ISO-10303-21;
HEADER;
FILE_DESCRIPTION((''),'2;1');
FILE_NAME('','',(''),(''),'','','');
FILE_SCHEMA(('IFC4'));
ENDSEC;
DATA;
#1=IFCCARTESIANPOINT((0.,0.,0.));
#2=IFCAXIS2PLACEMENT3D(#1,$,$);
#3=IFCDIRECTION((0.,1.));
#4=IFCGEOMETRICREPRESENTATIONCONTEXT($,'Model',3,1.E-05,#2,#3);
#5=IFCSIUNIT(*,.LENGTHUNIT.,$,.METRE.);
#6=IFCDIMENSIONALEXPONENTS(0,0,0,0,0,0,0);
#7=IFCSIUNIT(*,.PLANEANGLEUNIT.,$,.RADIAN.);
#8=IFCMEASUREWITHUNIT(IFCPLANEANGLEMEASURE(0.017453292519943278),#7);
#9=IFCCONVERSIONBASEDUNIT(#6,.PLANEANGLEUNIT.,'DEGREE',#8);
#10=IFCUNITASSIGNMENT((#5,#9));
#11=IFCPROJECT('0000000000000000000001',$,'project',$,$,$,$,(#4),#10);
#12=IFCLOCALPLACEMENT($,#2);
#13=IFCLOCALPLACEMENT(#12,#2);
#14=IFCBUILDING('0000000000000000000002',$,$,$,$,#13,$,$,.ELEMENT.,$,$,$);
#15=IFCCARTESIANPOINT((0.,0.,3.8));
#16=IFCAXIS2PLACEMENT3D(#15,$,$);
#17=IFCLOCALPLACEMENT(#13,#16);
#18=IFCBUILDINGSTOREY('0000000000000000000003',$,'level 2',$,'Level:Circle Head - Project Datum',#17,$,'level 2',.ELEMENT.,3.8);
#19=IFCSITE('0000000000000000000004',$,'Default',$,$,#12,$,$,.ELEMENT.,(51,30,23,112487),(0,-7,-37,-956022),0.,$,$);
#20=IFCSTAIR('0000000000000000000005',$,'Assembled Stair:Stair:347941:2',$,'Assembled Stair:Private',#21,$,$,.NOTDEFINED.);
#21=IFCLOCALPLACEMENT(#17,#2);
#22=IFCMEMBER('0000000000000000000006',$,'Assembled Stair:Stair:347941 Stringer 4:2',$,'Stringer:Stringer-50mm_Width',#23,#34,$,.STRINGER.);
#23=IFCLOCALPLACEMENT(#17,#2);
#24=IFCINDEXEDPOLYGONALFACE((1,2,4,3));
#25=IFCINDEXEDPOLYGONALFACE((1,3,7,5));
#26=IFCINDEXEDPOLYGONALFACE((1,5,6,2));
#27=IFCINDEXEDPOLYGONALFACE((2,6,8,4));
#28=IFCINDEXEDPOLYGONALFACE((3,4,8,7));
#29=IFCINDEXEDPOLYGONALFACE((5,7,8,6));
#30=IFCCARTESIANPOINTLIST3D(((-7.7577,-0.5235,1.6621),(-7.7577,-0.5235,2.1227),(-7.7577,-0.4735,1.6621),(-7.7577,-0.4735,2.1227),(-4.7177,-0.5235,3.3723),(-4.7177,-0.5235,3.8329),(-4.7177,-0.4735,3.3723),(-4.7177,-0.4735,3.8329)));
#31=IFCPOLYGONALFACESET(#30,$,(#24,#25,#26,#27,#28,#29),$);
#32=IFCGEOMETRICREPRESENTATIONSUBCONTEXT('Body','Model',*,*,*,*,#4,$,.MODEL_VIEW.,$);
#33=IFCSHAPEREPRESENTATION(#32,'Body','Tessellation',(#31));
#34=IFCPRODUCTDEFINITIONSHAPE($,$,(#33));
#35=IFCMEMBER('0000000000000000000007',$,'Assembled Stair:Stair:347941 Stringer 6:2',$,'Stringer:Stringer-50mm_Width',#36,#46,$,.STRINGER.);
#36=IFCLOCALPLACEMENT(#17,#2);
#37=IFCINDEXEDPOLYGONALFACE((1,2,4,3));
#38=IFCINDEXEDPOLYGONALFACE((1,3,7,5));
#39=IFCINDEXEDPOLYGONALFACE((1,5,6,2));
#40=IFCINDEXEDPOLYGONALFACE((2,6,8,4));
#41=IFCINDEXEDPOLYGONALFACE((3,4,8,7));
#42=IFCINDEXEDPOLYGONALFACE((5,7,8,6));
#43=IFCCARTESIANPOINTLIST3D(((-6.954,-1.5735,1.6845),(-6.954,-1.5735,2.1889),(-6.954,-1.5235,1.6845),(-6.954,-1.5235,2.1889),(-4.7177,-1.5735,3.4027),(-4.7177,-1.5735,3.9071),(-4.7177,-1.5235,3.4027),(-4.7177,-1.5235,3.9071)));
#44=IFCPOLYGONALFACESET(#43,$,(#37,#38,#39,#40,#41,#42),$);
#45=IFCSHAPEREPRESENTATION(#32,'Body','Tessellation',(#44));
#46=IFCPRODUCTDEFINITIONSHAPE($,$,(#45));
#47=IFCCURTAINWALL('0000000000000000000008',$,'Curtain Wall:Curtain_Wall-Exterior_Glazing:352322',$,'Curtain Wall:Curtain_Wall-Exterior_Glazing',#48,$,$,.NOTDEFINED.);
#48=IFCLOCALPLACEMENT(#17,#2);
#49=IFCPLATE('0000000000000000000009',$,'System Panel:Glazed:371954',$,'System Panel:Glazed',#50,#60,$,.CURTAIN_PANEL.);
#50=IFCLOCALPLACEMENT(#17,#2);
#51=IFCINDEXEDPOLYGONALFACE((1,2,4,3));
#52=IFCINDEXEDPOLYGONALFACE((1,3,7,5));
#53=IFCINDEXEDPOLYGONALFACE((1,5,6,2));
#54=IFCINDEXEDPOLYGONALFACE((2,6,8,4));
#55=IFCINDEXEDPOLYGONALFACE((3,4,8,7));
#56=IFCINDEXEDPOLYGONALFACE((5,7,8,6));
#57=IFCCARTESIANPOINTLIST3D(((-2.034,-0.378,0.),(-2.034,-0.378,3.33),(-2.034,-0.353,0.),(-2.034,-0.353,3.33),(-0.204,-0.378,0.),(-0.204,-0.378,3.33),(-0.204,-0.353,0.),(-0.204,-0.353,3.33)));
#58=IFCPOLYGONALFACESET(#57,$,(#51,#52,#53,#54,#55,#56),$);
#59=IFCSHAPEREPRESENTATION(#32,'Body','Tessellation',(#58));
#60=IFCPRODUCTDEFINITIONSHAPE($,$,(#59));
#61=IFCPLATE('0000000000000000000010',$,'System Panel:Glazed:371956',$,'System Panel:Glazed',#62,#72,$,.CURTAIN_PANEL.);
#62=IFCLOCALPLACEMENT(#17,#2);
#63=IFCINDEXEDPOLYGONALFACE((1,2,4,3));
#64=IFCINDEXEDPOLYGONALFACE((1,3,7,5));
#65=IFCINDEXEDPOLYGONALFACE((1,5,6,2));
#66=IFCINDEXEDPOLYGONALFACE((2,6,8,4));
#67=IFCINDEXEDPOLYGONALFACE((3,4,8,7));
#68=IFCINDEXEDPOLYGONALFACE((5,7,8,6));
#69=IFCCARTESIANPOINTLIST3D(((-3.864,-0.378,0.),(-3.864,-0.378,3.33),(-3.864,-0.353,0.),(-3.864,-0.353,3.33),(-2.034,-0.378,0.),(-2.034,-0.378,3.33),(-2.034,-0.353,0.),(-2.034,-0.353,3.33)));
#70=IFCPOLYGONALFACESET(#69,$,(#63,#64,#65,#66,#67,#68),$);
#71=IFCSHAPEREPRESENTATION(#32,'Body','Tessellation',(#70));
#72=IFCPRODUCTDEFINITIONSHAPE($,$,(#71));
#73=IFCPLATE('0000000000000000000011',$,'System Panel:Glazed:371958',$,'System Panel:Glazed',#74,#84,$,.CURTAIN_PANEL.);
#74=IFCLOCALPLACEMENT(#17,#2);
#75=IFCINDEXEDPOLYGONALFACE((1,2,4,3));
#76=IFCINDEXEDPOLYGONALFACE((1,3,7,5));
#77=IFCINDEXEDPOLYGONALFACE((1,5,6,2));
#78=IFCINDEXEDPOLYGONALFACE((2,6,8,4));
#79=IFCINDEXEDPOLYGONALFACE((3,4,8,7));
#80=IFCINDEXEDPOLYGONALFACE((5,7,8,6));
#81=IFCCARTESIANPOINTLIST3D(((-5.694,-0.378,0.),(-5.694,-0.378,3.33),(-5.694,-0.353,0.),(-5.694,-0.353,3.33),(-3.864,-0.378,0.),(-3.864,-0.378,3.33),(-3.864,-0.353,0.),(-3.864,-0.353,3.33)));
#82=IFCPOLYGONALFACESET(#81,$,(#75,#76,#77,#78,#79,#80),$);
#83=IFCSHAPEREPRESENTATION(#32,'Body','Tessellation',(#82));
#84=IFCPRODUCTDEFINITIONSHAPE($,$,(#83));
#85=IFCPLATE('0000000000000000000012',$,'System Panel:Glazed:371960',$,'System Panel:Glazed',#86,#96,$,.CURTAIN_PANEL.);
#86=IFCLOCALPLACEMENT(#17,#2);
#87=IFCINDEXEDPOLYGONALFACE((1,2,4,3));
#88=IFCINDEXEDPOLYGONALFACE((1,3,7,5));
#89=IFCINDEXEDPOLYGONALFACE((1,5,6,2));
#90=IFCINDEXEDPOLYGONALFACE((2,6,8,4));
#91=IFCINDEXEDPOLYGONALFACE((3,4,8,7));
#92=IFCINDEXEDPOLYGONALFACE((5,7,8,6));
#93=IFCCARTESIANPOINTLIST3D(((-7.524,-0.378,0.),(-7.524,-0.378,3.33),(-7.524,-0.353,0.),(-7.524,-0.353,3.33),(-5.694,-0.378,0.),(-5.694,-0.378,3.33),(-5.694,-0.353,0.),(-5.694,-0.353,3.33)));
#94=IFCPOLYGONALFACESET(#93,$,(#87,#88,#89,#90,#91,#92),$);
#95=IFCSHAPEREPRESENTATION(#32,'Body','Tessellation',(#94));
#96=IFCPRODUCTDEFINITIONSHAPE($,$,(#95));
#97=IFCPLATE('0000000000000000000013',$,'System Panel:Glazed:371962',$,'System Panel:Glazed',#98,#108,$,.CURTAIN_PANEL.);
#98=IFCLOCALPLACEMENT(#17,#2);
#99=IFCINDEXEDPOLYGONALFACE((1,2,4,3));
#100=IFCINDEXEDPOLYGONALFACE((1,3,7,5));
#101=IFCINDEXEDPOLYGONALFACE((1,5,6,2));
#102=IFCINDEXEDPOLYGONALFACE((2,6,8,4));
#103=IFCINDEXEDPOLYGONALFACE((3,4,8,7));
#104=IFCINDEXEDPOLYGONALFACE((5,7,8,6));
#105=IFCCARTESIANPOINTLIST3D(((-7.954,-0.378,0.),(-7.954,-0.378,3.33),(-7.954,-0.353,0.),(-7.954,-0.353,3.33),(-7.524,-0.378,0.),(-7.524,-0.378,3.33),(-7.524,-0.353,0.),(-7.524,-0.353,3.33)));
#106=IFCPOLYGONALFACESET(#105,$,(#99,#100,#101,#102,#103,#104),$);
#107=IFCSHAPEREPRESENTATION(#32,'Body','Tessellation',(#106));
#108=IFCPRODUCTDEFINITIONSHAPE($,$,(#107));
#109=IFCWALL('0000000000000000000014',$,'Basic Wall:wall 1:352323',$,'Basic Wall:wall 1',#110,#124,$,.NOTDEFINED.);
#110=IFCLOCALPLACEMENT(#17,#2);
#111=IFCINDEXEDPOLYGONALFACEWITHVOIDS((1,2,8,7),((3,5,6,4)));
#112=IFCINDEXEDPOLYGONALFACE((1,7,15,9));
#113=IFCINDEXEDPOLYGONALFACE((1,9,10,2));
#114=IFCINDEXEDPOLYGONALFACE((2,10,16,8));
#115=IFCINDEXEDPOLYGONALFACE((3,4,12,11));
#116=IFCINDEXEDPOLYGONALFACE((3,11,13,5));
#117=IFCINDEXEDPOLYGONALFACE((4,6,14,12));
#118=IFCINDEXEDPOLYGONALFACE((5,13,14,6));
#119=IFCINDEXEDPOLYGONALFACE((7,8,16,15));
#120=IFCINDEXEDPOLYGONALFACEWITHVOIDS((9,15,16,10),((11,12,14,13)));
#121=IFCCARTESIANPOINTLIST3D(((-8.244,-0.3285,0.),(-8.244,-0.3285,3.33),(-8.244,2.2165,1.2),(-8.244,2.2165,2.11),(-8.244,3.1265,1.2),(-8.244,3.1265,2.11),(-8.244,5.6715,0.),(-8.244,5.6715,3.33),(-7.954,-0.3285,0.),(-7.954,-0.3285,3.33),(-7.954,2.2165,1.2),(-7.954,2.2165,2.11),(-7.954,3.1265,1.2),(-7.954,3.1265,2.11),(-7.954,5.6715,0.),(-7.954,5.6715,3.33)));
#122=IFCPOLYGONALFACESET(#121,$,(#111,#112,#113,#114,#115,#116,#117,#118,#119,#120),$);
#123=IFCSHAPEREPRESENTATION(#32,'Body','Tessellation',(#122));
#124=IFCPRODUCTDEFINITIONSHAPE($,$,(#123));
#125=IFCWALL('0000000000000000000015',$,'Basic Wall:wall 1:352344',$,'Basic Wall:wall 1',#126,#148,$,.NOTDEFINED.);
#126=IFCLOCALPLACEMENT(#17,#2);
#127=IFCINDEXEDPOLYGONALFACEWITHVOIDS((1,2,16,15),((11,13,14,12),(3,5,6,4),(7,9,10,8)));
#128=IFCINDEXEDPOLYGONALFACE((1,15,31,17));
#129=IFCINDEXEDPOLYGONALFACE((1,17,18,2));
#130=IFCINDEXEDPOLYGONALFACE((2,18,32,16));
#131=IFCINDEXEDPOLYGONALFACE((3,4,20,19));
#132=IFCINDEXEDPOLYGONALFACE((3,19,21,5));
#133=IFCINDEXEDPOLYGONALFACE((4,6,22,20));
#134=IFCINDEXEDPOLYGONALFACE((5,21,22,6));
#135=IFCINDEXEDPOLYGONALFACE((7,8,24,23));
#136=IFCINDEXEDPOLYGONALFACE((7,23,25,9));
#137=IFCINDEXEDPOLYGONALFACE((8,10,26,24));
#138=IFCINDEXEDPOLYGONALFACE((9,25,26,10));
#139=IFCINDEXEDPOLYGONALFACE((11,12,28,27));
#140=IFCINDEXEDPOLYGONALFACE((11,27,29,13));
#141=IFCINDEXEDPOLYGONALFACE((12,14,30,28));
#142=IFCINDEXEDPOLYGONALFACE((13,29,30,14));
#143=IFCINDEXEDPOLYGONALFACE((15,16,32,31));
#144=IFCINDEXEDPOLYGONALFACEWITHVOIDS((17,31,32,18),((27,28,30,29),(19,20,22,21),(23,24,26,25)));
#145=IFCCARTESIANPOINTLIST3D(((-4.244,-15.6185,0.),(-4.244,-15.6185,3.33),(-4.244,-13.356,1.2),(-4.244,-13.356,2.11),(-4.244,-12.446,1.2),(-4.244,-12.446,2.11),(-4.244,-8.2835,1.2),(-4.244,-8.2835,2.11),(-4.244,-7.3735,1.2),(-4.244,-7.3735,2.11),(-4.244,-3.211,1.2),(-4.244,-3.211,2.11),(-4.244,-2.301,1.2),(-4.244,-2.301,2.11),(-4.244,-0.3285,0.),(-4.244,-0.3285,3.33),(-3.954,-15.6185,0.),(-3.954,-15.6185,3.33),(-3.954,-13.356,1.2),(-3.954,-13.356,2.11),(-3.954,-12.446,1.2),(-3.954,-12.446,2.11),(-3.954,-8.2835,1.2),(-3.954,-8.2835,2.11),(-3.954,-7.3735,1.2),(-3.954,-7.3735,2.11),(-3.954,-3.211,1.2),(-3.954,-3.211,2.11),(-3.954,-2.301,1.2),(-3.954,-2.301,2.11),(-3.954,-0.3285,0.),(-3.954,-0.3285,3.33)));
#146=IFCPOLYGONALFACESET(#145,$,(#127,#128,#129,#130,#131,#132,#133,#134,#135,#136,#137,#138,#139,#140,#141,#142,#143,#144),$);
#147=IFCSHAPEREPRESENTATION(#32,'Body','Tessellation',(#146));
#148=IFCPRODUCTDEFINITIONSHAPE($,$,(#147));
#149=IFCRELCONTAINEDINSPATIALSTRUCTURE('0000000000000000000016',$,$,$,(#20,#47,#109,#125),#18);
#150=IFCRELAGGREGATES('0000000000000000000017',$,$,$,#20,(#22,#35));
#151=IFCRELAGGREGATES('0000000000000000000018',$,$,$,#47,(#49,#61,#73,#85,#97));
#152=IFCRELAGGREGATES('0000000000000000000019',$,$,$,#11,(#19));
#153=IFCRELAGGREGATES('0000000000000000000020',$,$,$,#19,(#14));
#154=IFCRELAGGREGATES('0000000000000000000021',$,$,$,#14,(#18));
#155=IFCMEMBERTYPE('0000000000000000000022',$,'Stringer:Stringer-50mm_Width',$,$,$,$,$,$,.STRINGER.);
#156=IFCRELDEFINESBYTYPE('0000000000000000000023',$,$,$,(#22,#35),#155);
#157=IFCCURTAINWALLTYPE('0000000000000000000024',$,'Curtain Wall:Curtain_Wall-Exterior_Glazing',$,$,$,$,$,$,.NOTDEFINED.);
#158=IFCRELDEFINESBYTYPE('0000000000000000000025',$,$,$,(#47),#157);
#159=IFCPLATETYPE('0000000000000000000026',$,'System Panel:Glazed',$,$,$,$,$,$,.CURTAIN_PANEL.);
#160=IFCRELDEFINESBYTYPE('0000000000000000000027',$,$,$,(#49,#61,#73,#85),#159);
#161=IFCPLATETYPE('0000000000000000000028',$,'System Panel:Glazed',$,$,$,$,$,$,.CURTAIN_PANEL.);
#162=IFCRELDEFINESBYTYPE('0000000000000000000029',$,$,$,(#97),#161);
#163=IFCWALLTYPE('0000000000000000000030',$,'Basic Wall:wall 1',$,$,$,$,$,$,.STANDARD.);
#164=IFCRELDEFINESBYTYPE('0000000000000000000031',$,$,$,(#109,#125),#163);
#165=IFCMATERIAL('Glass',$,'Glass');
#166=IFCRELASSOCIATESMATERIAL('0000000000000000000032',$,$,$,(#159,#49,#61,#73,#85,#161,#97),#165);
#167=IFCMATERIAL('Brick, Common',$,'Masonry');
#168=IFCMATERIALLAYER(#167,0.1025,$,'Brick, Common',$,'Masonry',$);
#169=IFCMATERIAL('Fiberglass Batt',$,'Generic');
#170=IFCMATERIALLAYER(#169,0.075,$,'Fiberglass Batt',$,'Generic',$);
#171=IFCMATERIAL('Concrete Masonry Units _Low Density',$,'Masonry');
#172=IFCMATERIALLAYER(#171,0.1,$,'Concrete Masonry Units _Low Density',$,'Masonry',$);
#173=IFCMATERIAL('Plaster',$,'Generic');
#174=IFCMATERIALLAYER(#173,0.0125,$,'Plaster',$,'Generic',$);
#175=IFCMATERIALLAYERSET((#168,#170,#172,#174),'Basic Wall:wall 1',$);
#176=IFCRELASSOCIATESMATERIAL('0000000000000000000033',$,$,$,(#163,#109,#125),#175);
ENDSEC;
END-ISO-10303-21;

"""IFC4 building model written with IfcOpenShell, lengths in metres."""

from ifc_helpers import new_model, entity, si_unit, converted_unit, direction, frame, frame_2d, origin, origin_2d_with_axis, place, context, subcontext, project, spatial, polyline, rectangle, outline, extrude, clip, bounded_halfspace, source, transform, mapped, material, layer, layer_set, layer_usage, type_object, type_shapes, element, aggregate, save


model = new_model("IFC4")

# Units and contexts
model_context = context("Model", 3, precision=1e-05, world=origin(), true_north=direction((0.0, 1.0)))
body_context = subcontext(model_context, "Body", "Model", "MODEL_VIEW")
ifc_project = project(units=[si_unit("LENGTHUNIT", "METRE"), converted_unit("PLANEANGLEUNIT", "DEGREE", entity("IfcPlaneAngleMeasure", 0.017453292519943278), si_unit("PLANEANGLEUNIT", "RADIAN"), dimensions=[0, 0, 0, 0, 0, 0, 0])], contexts=[model_context])

# Site, building, storey
site_placement = place(None, origin())
site = spatial("IfcSite", under=ifc_project, at=site_placement, Name="Default", CompositionType="ELEMENT", RefLatitude=(51, 30, 23, 112487), RefLongitude=(0, -7, -37, -956022), RefElevation=0.0)
building_placement = place(site_placement, origin())
building = spatial("IfcBuilding", under=site, at=building_placement, CompositionType="ELEMENT")
storey_placement = place(building_placement, frame((0.0, 0.0, 3.8)))
storey = spatial("IfcBuildingStorey", under=building, at=storey_placement, Name="level 2", ObjectType="Level:Circle Head - Project Datum", LongName="level 2", CompositionType="ELEMENT", Elevation=3.8)

# Stair, members
stair_placement = place(storey_placement, origin())
stair = element("IfcStair", 1, at=stair_placement, inside=storey, Name="Assembled Stair:Stair:347941:2", ObjectType="Assembled Stair:Private", PredefinedType="NOTDEFINED")
member_type = type_object("IfcMemberType", Name="Stringer:Stringer-50mm_Width", PredefinedType="STRINGER")
member_1_placement = place(stair_placement, frame((-7.7577, -0.5235, 1.6621)))
member_1 = element("IfcMember", 2, at=member_1_placement, type_object=member_type, Name="Assembled Stair:Stair:347941 Stringer 4:2", ObjectType="Stringer:Stringer-50mm_Width", PredefinedType="STRINGER", context=body_context, shape_type="SweptSolid", body=[
    extrude(outline(polyline([(-1.6311, -0.2007), (1.857, -0.2007), (1.6311, 0.2007), (-1.857, 0.2007), (-1.6311, -0.2007)])), frame((1.52, 0.0, 1.0854), z_axis=(0.0, 1.0, 0.0), x_axis=(0.871553, 0.0, 0.490302)), (0.0, 0.0, 1.0), 0.05),
])
member_2_placement = place(stair_placement, frame((-6.954, -1.5735, 1.6845)))
member_2 = element("IfcMember", 3, at=member_2_placement, type_object=member_type, Name="Assembled Stair:Stair:347941 Stringer 6:2", ObjectType="Stringer:Stringer-50mm_Width", PredefinedType="STRINGER", context=body_context, shape_type="SweptSolid", body=[
    extrude(outline(polyline([(-1.2564, -0.2), (1.5637, -0.2), (1.2564, 0.2), (-1.5637, 0.2), (-1.2564, -0.2)])), frame((1.1182, 0.0, 1.1113), z_axis=(0.0, 1.0, 0.0), x_axis=(0.792984, 0.0, 0.609242)), (0.0, 0.0, 1.0), 0.05),
])
aggregate(stair, [member_1, member_2])

# Curtain wall, plates
curtain_wall_type = type_object("IfcCurtainWallType", Name="Curtain Wall:Curtain_Wall-Exterior_Glazing", PredefinedType="NOTDEFINED")
curtain_wall_placement = place(storey_placement, frame((0.0, 0.0, -3.8)))
curtain_wall = element("IfcCurtainWall", 4, at=curtain_wall_placement, inside=storey, type_object=curtain_wall_type, Name="Curtain Wall:Curtain_Wall-Exterior_Glazing:352322", ObjectType="Curtain Wall:Curtain_Wall-Exterior_Glazing", PredefinedType="NOTDEFINED")
ifc_material_1 = material(Name="Glass", Category="Glass")
plate_type_1 = type_object("IfcPlateType", Name="System Panel:Glazed", PredefinedType="CURTAIN_PANEL", material=ifc_material_1)
shared_shape_1 = source(origin(), body_context, "Body", "SweptSolid", [
    extrude(rectangle(XDim=0.025, YDim=1.83, at=origin_2d_with_axis()), frame((0.915, 0.0125, 0.0), z_axis=(0.0, 0.0, 1.0), x_axis=(0.0, 1.0, 0.0)), (0.0, 0.0, 1.0), 3.33),
])
type_shapes(plate_type_1, [shared_shape_1])
plate_1_placement = place(curtain_wall_placement, frame((-0.204, -0.353, 3.8), z_axis=(0.0, 0.0, 1.0), x_axis=(-1.0, 0.0, 0.0)))
plate_1 = element("IfcPlate", 5, at=plate_1_placement, type_object=plate_type_1, material=ifc_material_1, Name="System Panel:Glazed:371954", ObjectType="System Panel:Glazed", PredefinedType="CURTAIN_PANEL", context=body_context, shape_type="MappedRepresentation", body=[
    mapped(shared_shape_1, transform((0.0, 0.0, 0.0), scale=1.0)),
])
plate_2_placement = place(curtain_wall_placement, frame((-2.034, -0.353, 3.8), z_axis=(0.0, 0.0, 1.0), x_axis=(-1.0, 0.0, 0.0)))
plate_2 = element("IfcPlate", 6, at=plate_2_placement, type_object=plate_type_1, material=ifc_material_1, Name="System Panel:Glazed:371956", ObjectType="System Panel:Glazed", PredefinedType="CURTAIN_PANEL", context=body_context, shape_type="MappedRepresentation", body=[
    mapped(shared_shape_1, transform((0.0, 0.0, 0.0), scale=1.0)),
])
plate_3_placement = place(curtain_wall_placement, frame((-3.864, -0.353, 3.8), z_axis=(0.0, 0.0, 1.0), x_axis=(-1.0, 0.0, 0.0)))
plate_3 = element("IfcPlate", 7, at=plate_3_placement, type_object=plate_type_1, material=ifc_material_1, Name="System Panel:Glazed:371958", ObjectType="System Panel:Glazed", PredefinedType="CURTAIN_PANEL", context=body_context, shape_type="MappedRepresentation", body=[
    mapped(shared_shape_1, transform((0.0, 0.0, 0.0), scale=1.0)),
])
plate_4_placement = place(curtain_wall_placement, frame((-5.694, -0.353, 3.8), z_axis=(0.0, 0.0, 1.0), x_axis=(-1.0, 0.0, 0.0)))
plate_4 = element("IfcPlate", 8, at=plate_4_placement, type_object=plate_type_1, material=ifc_material_1, Name="System Panel:Glazed:371960", ObjectType="System Panel:Glazed", PredefinedType="CURTAIN_PANEL", context=body_context, shape_type="MappedRepresentation", body=[
    mapped(shared_shape_1, transform((0.0, 0.0, 0.0), scale=1.0)),
])
plate_type_2 = type_object("IfcPlateType", Name="System Panel:Glazed", PredefinedType="CURTAIN_PANEL", material=ifc_material_1)
shared_shape_2 = source(origin(), body_context, "Body", "SweptSolid", [
    extrude(rectangle(XDim=0.025, YDim=0.43, at=origin_2d_with_axis()), frame((0.215, 0.0125, 0.0), z_axis=(0.0, 0.0, 1.0), x_axis=(0.0, 1.0, 0.0)), (0.0, 0.0, 1.0), 3.33),
])
type_shapes(plate_type_2, [shared_shape_2])
plate_5_placement = place(curtain_wall_placement, frame((-7.524, -0.353, 3.8), z_axis=(0.0, 0.0, 1.0), x_axis=(-1.0, 0.0, 0.0)))
plate_5 = element("IfcPlate", 9, at=plate_5_placement, type_object=plate_type_2, material=ifc_material_1, Name="System Panel:Glazed:371962", ObjectType="System Panel:Glazed", PredefinedType="CURTAIN_PANEL", context=body_context, shape_type="MappedRepresentation", body=[
    mapped(shared_shape_2, transform((0.0, 0.0, 0.0), scale=1.0)),
])
aggregate(curtain_wall, [plate_1, plate_2, plate_3, plate_4, plate_5])

# Wall, opening
ifc_material_2 = material(Name="Brick, Common", Category="Masonry")
ifc_layer_1 = layer(ifc_material_2, 0.1025, Name="Brick, Common", Category="Masonry")
ifc_material_3 = material(Name="Fiberglass Batt", Category="Generic")
ifc_layer_2 = layer(ifc_material_3, 0.075, Name="Fiberglass Batt", Category="Generic")
ifc_material_4 = material(Name="Concrete Masonry Units _Low Density", Category="Masonry")
ifc_layer_3 = layer(ifc_material_4, 0.1, Name="Concrete Masonry Units _Low Density", Category="Masonry")
ifc_material_5 = material(Name="Plaster", Category="Generic")
ifc_layer_4 = layer(ifc_material_5, 0.0125, Name="Plaster", Category="Generic")
ifc_layer_set = layer_set([ifc_layer_1, ifc_layer_2, ifc_layer_3, ifc_layer_4], Name="Basic Wall:wall 1")
ifc_layer_usage_1 = layer_usage(ifc_layer_set, "AXIS2", "NEGATIVE", 0.145)
wall_type = type_object("IfcWallType", Name="Basic Wall:wall 1", PredefinedType="STANDARD", material=ifc_layer_set)
wall_1_placement = place(storey_placement, frame((-8.099, -0.3285, 0.0), z_axis=(0.0, 0.0, 1.0), x_axis=(0.0, 1.0, 0.0)))
wall_1 = element("IfcWall", 10, at=wall_1_placement, inside=storey, type_object=wall_type, material=ifc_layer_usage_1, Name="Basic Wall:wall 1:352323", ObjectType="Basic Wall:wall 1", PredefinedType="NOTDEFINED", context=body_context, shape_type="Clipping", body=[
    clip(extrude(rectangle(XDim=6.0, YDim=0.29, at=frame_2d((3.0, 0.0), x_axis=(-1.0, 0.0))), origin(), (0.0, 0.0, 1.0), 3.33), bounded_halfspace(frame((0.0, -0.145, 3.33), z_axis=(0.0, 0.0, -1.0), x_axis=(1.0, 0.0, 0.0)), True, frame((0.0, -0.145, 3.33)), polyline([(0.0, 0.0), (6.0, 0.0), (6.0, 0.29), (0.0, 0.29), (0.0, 0.0)]))),
])
opening_1_placement = place(wall_1_placement, frame((2.545, -0.145, 1.2)))
element("IfcOpeningElement", 11, at=opening_1_placement, cuts=wall_1, PredefinedType="OPENING", context=body_context, shape_type="SweptSolid", body=[
    extrude(rectangle(XDim=0.91, YDim=0.91, at=frame_2d((0.455, 0.455), x_axis=(-1.0, 0.0))), frame((0.0, 0.0, 0.0), z_axis=(0.0, 1.0, 0.0), x_axis=(0.0, 0.0, 1.0)), (0.0, 0.0, 1.0), 0.29),
])

# Wall, openings
ifc_layer_usage_2 = layer_usage(ifc_layer_set, "AXIS2", "NEGATIVE", 0.145)
wall_2_placement = place(storey_placement, frame((-4.099, -0.3285, 0.0), z_axis=(0.0, 0.0, 1.0), x_axis=(0.0, -1.0, 0.0)))
wall_2 = element("IfcWall", 12, at=wall_2_placement, inside=storey, type_object=wall_type, material=ifc_layer_usage_2, Name="Basic Wall:wall 1:352344", ObjectType="Basic Wall:wall 1", PredefinedType="NOTDEFINED", context=body_context, shape_type="Clipping", body=[
    clip(extrude(rectangle(XDim=15.29, YDim=0.29, at=frame_2d((7.645, 0.0), x_axis=(-1.0, 0.0))), origin(), (0.0, 0.0, 1.0), 3.33), bounded_halfspace(frame((0.0, -0.145, 3.33), z_axis=(0.0, 0.0, -1.0), x_axis=(-1.0, 0.0, 0.0)), True, frame((0.0, -0.145, 3.33)), polyline([(0.0, 0.0), (4.9375, 0.0), (5.0625, 0.0), (9.9375, 0.0), (10.0625, 0.0), (15.0, 0.0), (15.29, 0.0), (15.29, 0.29), (0.0, 0.29), (0.0, 0.0)]))),
])
opening_2_placement = place(wall_2_placement, frame((12.1175, -0.145, 1.2)))
element("IfcOpeningElement", 13, at=opening_2_placement, cuts=wall_2, PredefinedType="OPENING", context=body_context, shape_type="SweptSolid", body=[
    extrude(rectangle(XDim=0.91, YDim=0.91, at=frame_2d((0.455, 0.455), x_axis=(-1.0, 0.0))), frame((0.0, 0.0, 0.0), z_axis=(0.0, 1.0, 0.0), x_axis=(0.0, 0.0, 1.0)), (0.0, 0.0, 1.0), 0.29),
])
opening_3_placement = place(wall_2_placement, frame((7.045, -0.145, 1.2)))
element("IfcOpeningElement", 14, at=opening_3_placement, cuts=wall_2, PredefinedType="OPENING", context=body_context, shape_type="SweptSolid", body=[
    extrude(rectangle(XDim=0.91, YDim=0.91, at=frame_2d((0.455, 0.455), x_axis=(-1.0, 0.0))), frame((0.0, 0.0, 0.0), z_axis=(0.0, 1.0, 0.0), x_axis=(0.0, 0.0, 1.0)), (0.0, 0.0, 1.0), 0.29),
])
opening_4_placement = place(wall_2_placement, frame((1.9725, -0.145, 1.2)))
element("IfcOpeningElement", 15, at=opening_4_placement, cuts=wall_2, PredefinedType="OPENING", context=body_context, shape_type="SweptSolid", body=[
    extrude(rectangle(XDim=0.91, YDim=0.91, at=frame_2d((0.455, 0.455), x_axis=(-1.0, 0.0))), frame((0.0, 0.0, 0.0), z_axis=(0.0, 1.0, 0.0), x_axis=(0.0, 0.0, 1.0)), (0.0, 0.0, 1.0), 0.29),
])

save(model, "model.ifc")
